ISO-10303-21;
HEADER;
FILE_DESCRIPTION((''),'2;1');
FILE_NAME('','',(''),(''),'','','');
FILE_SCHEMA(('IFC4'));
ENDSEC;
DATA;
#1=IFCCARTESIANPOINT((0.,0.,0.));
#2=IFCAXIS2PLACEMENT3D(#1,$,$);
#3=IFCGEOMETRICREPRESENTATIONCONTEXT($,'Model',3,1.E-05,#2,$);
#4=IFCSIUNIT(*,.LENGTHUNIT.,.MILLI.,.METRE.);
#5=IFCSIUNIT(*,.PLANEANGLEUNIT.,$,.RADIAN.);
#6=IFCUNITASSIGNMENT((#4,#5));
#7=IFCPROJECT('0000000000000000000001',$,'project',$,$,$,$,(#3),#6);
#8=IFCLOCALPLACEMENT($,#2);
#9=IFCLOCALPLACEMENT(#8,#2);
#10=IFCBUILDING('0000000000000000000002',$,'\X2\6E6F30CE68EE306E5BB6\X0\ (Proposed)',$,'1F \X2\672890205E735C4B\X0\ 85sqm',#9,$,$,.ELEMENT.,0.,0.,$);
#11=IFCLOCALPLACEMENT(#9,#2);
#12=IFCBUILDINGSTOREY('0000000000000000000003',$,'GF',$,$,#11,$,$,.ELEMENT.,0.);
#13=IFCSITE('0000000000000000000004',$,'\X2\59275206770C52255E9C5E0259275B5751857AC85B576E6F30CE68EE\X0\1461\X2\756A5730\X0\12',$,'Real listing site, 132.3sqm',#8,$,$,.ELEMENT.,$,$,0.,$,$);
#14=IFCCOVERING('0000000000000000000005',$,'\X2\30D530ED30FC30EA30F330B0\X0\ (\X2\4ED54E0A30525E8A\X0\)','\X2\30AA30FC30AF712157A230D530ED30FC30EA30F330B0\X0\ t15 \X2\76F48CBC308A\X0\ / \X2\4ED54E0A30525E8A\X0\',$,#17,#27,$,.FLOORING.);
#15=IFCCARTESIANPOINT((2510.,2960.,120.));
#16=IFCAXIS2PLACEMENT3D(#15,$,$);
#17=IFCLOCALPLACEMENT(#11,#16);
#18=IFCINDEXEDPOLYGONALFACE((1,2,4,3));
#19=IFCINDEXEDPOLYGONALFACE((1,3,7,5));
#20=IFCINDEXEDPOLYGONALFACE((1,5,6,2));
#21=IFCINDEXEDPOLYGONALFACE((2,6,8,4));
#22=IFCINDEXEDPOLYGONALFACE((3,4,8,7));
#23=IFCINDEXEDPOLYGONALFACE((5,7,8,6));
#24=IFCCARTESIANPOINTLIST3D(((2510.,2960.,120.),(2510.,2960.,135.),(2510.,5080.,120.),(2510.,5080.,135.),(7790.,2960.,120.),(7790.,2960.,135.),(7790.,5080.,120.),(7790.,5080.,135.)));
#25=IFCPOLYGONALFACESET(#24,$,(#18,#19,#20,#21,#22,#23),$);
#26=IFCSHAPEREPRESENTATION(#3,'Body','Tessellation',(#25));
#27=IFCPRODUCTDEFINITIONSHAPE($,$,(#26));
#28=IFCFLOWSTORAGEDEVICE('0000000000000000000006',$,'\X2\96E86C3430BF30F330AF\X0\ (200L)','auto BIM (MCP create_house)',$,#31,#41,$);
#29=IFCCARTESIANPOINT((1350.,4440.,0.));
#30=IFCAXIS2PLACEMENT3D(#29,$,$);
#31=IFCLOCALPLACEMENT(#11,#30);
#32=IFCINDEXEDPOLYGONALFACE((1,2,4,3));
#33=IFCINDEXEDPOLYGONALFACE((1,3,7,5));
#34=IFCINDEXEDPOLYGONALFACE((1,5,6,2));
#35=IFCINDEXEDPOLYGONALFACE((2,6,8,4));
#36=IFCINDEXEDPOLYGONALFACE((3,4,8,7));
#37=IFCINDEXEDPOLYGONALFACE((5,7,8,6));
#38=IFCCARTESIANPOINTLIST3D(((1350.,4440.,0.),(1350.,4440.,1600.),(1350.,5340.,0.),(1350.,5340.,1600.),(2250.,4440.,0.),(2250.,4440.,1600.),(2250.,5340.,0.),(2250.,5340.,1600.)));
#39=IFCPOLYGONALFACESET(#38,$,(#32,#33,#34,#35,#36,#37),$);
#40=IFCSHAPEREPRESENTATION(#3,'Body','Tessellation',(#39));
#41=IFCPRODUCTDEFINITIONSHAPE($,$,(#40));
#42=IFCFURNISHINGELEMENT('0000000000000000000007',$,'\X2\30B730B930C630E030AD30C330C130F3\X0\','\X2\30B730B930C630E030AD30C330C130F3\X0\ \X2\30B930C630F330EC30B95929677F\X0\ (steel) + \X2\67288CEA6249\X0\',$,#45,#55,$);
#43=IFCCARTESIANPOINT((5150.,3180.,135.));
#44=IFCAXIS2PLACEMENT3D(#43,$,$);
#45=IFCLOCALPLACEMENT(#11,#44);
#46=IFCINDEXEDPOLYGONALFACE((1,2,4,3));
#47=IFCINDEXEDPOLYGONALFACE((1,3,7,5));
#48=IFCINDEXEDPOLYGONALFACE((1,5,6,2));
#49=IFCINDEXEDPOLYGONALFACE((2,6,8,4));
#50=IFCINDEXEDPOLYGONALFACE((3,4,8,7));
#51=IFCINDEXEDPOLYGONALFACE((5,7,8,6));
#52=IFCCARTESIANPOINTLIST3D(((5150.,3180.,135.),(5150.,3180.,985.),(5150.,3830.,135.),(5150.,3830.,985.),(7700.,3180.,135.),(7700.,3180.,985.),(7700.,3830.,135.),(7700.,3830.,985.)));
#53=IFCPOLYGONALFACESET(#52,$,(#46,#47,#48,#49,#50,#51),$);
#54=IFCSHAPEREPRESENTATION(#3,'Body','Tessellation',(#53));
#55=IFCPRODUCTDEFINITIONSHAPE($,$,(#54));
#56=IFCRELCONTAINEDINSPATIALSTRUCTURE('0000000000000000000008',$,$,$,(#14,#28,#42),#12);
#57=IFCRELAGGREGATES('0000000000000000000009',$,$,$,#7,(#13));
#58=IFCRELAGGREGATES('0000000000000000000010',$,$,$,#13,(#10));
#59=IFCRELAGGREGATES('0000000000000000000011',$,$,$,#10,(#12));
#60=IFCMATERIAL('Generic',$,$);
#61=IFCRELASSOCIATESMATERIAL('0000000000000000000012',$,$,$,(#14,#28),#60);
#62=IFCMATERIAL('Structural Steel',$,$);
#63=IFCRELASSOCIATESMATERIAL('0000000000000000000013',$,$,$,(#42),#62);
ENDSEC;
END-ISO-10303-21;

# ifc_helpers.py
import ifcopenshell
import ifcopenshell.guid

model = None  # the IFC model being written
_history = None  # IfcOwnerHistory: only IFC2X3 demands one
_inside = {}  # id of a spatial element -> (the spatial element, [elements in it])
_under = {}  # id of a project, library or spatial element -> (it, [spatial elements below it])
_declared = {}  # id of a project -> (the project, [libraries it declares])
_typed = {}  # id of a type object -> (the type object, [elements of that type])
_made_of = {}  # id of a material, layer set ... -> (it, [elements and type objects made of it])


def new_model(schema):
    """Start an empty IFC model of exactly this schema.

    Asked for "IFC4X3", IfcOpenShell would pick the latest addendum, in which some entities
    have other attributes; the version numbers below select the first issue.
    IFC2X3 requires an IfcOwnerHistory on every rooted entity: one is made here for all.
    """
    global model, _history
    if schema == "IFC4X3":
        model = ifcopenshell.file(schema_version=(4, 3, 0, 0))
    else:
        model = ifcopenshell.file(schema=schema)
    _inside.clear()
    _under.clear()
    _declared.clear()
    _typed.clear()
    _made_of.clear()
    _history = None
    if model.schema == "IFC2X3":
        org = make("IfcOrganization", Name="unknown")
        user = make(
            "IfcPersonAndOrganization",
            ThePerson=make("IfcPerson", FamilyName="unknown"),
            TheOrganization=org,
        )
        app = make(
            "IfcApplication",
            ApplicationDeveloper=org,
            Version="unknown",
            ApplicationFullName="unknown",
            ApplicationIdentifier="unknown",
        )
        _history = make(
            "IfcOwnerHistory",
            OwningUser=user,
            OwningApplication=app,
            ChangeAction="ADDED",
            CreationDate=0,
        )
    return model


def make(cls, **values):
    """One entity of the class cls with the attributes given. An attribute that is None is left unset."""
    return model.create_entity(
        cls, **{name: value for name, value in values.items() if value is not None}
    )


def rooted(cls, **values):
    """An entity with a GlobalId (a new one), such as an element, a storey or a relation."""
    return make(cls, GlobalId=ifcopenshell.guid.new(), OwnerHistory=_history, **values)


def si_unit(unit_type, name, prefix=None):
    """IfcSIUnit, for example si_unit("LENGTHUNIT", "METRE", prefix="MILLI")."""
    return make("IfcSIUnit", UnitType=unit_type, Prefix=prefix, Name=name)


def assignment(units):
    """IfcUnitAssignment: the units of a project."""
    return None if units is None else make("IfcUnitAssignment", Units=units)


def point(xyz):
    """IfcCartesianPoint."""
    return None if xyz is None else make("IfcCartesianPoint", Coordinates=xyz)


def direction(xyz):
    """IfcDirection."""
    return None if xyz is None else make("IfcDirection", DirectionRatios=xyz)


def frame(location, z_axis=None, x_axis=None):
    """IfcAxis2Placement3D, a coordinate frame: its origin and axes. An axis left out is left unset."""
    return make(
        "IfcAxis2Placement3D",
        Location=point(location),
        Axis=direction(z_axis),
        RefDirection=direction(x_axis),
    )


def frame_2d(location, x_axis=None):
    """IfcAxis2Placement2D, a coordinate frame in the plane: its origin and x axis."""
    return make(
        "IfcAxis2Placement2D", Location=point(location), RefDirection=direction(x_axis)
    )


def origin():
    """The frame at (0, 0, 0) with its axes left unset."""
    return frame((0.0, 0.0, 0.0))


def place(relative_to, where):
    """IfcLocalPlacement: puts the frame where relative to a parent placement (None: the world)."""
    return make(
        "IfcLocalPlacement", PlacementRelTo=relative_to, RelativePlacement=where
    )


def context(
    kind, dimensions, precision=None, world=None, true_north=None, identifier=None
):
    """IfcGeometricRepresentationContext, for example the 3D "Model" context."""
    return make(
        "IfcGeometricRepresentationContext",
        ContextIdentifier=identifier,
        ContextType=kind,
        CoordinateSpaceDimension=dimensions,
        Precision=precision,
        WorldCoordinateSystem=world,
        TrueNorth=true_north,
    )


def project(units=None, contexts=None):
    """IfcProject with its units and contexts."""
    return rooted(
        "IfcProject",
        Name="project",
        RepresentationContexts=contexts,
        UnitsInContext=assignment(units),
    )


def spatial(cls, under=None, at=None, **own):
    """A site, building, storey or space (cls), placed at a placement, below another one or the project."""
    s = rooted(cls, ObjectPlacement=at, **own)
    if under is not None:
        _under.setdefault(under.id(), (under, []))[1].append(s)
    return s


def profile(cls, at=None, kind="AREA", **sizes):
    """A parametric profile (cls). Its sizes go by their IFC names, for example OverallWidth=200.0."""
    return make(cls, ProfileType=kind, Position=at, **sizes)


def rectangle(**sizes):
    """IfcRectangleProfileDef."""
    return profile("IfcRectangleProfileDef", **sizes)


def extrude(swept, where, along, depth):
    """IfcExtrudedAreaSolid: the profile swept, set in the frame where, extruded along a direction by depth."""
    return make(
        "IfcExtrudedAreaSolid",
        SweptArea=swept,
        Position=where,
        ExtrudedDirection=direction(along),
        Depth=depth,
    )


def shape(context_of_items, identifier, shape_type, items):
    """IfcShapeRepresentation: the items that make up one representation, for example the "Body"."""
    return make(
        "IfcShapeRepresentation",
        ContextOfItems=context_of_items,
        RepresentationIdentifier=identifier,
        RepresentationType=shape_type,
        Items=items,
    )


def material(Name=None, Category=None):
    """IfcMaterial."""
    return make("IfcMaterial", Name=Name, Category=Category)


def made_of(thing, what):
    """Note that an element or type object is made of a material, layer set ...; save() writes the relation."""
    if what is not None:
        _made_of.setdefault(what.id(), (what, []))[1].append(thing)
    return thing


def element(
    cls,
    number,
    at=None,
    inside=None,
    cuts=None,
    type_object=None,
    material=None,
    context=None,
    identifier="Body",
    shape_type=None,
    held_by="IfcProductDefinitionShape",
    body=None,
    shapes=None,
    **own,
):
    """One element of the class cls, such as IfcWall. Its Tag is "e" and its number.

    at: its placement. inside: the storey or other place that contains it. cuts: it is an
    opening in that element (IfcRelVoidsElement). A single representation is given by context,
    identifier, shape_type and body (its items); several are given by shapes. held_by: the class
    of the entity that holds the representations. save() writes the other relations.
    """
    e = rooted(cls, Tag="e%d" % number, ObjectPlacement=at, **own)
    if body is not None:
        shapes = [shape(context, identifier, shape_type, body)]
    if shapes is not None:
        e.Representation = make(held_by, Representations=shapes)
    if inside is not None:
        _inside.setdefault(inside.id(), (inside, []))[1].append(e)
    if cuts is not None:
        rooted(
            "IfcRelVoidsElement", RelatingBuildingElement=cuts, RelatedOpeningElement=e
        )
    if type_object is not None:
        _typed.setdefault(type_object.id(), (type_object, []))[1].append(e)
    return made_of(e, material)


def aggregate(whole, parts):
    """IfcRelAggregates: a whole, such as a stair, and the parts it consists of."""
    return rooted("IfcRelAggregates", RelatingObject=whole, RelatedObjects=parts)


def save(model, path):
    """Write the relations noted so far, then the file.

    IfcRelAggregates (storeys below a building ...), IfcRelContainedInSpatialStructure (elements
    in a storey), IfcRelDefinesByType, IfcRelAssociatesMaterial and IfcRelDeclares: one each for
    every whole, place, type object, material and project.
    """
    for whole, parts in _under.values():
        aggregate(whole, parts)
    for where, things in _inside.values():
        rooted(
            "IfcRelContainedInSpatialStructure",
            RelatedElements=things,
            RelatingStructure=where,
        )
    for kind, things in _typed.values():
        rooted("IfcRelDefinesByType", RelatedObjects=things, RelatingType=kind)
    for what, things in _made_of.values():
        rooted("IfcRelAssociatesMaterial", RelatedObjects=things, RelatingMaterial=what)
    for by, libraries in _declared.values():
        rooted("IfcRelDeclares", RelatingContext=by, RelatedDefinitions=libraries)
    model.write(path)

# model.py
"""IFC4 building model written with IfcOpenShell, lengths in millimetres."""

from ifc_helpers import new_model, si_unit, frame, frame_2d, origin, place, context, project, spatial, rectangle, extrude, material, element, save


model = new_model("IFC4")

# Units and contexts
model_context = context("Model", 3, precision=1e-05, world=origin())
ifc_project = project(units=[si_unit("LENGTHUNIT", "METRE", prefix="MILLI"), si_unit("PLANEANGLEUNIT", "RADIAN")], contexts=[model_context])

# Site, building, storey
site_placement = place(None, origin())
site = spatial("IfcSite", under=ifc_project, at=site_placement, Name="大分県別府市大字内竈字湯ノ森1461番地12", ObjectType="Real listing site, 132.3sqm", CompositionType="ELEMENT", RefElevation=0.0)
building_placement = place(site_placement, origin())
building = spatial("IfcBuilding", under=site, at=building_placement, Name="湯ノ森の家 (Proposed)", ObjectType="1F 木造平屋 85sqm", CompositionType="ELEMENT", ElevationOfRefHeight=0.0, ElevationOfTerrain=0.0)
storey_placement = place(building_placement, origin())
storey = spatial("IfcBuildingStorey", under=building, at=storey_placement, Name="GF", CompositionType="ELEMENT", Elevation=0.0)

# Shared definitions
ifc_material_1 = material(Name="Generic")

# Covering
covering_placement = place(storey_placement, frame((2510.0, 2960.0, 120.0)))
element("IfcCovering", 1, at=covering_placement, inside=storey, material=ifc_material_1, Name="フローリング (仕上げ床)", Description="オーク無垢フローリング t15 直貼り / 仕上げ床", PredefinedType="FLOORING", context=model_context, shape_type="SweptSolid", body=[
    extrude(rectangle(XDim=5280.0, YDim=2120.0, at=frame_2d((2640.0, 1060.0))), frame((2510.0, 2960.0, 120.0)), (0.0, 0.0, 1.0), 15.0),
])

# Flow storage device
flow_storage_device_placement = place(storey_placement, frame((1350.0, 4440.0, 0.0)))
element("IfcFlowStorageDevice", 2, at=flow_storage_device_placement, inside=storey, material=ifc_material_1, Name="雨水タンク (200L)", Description="auto BIM (MCP create_house)", context=model_context, shape_type="SweptSolid", body=[
    extrude(rectangle(XDim=900.0, YDim=900.0, at=frame_2d((450.0, 450.0))), frame((1350.0, 4440.0, 0.0)), (0.0, 0.0, 1.0), 1600.0),
])

# Furnishing element
ifc_material_2 = material(Name="Structural Steel")
furnishing_placement = place(storey_placement, frame((5150.0, 3180.0, 135.0)))
element("IfcFurnishingElement", 3, at=furnishing_placement, inside=storey, material=ifc_material_2, Name="システムキッチン", Description="システムキッチン ステンレス天板 (steel) + 木質扉", context=model_context, shape_type="SweptSolid", body=[
    extrude(rectangle(XDim=2550.0, YDim=650.0, at=frame_2d((1275.0, 325.0))), frame((5150.0, 3180.0, 135.0)), (0.0, 0.0, 1.0), 850.0),
])

save(model, "model.ifc")
